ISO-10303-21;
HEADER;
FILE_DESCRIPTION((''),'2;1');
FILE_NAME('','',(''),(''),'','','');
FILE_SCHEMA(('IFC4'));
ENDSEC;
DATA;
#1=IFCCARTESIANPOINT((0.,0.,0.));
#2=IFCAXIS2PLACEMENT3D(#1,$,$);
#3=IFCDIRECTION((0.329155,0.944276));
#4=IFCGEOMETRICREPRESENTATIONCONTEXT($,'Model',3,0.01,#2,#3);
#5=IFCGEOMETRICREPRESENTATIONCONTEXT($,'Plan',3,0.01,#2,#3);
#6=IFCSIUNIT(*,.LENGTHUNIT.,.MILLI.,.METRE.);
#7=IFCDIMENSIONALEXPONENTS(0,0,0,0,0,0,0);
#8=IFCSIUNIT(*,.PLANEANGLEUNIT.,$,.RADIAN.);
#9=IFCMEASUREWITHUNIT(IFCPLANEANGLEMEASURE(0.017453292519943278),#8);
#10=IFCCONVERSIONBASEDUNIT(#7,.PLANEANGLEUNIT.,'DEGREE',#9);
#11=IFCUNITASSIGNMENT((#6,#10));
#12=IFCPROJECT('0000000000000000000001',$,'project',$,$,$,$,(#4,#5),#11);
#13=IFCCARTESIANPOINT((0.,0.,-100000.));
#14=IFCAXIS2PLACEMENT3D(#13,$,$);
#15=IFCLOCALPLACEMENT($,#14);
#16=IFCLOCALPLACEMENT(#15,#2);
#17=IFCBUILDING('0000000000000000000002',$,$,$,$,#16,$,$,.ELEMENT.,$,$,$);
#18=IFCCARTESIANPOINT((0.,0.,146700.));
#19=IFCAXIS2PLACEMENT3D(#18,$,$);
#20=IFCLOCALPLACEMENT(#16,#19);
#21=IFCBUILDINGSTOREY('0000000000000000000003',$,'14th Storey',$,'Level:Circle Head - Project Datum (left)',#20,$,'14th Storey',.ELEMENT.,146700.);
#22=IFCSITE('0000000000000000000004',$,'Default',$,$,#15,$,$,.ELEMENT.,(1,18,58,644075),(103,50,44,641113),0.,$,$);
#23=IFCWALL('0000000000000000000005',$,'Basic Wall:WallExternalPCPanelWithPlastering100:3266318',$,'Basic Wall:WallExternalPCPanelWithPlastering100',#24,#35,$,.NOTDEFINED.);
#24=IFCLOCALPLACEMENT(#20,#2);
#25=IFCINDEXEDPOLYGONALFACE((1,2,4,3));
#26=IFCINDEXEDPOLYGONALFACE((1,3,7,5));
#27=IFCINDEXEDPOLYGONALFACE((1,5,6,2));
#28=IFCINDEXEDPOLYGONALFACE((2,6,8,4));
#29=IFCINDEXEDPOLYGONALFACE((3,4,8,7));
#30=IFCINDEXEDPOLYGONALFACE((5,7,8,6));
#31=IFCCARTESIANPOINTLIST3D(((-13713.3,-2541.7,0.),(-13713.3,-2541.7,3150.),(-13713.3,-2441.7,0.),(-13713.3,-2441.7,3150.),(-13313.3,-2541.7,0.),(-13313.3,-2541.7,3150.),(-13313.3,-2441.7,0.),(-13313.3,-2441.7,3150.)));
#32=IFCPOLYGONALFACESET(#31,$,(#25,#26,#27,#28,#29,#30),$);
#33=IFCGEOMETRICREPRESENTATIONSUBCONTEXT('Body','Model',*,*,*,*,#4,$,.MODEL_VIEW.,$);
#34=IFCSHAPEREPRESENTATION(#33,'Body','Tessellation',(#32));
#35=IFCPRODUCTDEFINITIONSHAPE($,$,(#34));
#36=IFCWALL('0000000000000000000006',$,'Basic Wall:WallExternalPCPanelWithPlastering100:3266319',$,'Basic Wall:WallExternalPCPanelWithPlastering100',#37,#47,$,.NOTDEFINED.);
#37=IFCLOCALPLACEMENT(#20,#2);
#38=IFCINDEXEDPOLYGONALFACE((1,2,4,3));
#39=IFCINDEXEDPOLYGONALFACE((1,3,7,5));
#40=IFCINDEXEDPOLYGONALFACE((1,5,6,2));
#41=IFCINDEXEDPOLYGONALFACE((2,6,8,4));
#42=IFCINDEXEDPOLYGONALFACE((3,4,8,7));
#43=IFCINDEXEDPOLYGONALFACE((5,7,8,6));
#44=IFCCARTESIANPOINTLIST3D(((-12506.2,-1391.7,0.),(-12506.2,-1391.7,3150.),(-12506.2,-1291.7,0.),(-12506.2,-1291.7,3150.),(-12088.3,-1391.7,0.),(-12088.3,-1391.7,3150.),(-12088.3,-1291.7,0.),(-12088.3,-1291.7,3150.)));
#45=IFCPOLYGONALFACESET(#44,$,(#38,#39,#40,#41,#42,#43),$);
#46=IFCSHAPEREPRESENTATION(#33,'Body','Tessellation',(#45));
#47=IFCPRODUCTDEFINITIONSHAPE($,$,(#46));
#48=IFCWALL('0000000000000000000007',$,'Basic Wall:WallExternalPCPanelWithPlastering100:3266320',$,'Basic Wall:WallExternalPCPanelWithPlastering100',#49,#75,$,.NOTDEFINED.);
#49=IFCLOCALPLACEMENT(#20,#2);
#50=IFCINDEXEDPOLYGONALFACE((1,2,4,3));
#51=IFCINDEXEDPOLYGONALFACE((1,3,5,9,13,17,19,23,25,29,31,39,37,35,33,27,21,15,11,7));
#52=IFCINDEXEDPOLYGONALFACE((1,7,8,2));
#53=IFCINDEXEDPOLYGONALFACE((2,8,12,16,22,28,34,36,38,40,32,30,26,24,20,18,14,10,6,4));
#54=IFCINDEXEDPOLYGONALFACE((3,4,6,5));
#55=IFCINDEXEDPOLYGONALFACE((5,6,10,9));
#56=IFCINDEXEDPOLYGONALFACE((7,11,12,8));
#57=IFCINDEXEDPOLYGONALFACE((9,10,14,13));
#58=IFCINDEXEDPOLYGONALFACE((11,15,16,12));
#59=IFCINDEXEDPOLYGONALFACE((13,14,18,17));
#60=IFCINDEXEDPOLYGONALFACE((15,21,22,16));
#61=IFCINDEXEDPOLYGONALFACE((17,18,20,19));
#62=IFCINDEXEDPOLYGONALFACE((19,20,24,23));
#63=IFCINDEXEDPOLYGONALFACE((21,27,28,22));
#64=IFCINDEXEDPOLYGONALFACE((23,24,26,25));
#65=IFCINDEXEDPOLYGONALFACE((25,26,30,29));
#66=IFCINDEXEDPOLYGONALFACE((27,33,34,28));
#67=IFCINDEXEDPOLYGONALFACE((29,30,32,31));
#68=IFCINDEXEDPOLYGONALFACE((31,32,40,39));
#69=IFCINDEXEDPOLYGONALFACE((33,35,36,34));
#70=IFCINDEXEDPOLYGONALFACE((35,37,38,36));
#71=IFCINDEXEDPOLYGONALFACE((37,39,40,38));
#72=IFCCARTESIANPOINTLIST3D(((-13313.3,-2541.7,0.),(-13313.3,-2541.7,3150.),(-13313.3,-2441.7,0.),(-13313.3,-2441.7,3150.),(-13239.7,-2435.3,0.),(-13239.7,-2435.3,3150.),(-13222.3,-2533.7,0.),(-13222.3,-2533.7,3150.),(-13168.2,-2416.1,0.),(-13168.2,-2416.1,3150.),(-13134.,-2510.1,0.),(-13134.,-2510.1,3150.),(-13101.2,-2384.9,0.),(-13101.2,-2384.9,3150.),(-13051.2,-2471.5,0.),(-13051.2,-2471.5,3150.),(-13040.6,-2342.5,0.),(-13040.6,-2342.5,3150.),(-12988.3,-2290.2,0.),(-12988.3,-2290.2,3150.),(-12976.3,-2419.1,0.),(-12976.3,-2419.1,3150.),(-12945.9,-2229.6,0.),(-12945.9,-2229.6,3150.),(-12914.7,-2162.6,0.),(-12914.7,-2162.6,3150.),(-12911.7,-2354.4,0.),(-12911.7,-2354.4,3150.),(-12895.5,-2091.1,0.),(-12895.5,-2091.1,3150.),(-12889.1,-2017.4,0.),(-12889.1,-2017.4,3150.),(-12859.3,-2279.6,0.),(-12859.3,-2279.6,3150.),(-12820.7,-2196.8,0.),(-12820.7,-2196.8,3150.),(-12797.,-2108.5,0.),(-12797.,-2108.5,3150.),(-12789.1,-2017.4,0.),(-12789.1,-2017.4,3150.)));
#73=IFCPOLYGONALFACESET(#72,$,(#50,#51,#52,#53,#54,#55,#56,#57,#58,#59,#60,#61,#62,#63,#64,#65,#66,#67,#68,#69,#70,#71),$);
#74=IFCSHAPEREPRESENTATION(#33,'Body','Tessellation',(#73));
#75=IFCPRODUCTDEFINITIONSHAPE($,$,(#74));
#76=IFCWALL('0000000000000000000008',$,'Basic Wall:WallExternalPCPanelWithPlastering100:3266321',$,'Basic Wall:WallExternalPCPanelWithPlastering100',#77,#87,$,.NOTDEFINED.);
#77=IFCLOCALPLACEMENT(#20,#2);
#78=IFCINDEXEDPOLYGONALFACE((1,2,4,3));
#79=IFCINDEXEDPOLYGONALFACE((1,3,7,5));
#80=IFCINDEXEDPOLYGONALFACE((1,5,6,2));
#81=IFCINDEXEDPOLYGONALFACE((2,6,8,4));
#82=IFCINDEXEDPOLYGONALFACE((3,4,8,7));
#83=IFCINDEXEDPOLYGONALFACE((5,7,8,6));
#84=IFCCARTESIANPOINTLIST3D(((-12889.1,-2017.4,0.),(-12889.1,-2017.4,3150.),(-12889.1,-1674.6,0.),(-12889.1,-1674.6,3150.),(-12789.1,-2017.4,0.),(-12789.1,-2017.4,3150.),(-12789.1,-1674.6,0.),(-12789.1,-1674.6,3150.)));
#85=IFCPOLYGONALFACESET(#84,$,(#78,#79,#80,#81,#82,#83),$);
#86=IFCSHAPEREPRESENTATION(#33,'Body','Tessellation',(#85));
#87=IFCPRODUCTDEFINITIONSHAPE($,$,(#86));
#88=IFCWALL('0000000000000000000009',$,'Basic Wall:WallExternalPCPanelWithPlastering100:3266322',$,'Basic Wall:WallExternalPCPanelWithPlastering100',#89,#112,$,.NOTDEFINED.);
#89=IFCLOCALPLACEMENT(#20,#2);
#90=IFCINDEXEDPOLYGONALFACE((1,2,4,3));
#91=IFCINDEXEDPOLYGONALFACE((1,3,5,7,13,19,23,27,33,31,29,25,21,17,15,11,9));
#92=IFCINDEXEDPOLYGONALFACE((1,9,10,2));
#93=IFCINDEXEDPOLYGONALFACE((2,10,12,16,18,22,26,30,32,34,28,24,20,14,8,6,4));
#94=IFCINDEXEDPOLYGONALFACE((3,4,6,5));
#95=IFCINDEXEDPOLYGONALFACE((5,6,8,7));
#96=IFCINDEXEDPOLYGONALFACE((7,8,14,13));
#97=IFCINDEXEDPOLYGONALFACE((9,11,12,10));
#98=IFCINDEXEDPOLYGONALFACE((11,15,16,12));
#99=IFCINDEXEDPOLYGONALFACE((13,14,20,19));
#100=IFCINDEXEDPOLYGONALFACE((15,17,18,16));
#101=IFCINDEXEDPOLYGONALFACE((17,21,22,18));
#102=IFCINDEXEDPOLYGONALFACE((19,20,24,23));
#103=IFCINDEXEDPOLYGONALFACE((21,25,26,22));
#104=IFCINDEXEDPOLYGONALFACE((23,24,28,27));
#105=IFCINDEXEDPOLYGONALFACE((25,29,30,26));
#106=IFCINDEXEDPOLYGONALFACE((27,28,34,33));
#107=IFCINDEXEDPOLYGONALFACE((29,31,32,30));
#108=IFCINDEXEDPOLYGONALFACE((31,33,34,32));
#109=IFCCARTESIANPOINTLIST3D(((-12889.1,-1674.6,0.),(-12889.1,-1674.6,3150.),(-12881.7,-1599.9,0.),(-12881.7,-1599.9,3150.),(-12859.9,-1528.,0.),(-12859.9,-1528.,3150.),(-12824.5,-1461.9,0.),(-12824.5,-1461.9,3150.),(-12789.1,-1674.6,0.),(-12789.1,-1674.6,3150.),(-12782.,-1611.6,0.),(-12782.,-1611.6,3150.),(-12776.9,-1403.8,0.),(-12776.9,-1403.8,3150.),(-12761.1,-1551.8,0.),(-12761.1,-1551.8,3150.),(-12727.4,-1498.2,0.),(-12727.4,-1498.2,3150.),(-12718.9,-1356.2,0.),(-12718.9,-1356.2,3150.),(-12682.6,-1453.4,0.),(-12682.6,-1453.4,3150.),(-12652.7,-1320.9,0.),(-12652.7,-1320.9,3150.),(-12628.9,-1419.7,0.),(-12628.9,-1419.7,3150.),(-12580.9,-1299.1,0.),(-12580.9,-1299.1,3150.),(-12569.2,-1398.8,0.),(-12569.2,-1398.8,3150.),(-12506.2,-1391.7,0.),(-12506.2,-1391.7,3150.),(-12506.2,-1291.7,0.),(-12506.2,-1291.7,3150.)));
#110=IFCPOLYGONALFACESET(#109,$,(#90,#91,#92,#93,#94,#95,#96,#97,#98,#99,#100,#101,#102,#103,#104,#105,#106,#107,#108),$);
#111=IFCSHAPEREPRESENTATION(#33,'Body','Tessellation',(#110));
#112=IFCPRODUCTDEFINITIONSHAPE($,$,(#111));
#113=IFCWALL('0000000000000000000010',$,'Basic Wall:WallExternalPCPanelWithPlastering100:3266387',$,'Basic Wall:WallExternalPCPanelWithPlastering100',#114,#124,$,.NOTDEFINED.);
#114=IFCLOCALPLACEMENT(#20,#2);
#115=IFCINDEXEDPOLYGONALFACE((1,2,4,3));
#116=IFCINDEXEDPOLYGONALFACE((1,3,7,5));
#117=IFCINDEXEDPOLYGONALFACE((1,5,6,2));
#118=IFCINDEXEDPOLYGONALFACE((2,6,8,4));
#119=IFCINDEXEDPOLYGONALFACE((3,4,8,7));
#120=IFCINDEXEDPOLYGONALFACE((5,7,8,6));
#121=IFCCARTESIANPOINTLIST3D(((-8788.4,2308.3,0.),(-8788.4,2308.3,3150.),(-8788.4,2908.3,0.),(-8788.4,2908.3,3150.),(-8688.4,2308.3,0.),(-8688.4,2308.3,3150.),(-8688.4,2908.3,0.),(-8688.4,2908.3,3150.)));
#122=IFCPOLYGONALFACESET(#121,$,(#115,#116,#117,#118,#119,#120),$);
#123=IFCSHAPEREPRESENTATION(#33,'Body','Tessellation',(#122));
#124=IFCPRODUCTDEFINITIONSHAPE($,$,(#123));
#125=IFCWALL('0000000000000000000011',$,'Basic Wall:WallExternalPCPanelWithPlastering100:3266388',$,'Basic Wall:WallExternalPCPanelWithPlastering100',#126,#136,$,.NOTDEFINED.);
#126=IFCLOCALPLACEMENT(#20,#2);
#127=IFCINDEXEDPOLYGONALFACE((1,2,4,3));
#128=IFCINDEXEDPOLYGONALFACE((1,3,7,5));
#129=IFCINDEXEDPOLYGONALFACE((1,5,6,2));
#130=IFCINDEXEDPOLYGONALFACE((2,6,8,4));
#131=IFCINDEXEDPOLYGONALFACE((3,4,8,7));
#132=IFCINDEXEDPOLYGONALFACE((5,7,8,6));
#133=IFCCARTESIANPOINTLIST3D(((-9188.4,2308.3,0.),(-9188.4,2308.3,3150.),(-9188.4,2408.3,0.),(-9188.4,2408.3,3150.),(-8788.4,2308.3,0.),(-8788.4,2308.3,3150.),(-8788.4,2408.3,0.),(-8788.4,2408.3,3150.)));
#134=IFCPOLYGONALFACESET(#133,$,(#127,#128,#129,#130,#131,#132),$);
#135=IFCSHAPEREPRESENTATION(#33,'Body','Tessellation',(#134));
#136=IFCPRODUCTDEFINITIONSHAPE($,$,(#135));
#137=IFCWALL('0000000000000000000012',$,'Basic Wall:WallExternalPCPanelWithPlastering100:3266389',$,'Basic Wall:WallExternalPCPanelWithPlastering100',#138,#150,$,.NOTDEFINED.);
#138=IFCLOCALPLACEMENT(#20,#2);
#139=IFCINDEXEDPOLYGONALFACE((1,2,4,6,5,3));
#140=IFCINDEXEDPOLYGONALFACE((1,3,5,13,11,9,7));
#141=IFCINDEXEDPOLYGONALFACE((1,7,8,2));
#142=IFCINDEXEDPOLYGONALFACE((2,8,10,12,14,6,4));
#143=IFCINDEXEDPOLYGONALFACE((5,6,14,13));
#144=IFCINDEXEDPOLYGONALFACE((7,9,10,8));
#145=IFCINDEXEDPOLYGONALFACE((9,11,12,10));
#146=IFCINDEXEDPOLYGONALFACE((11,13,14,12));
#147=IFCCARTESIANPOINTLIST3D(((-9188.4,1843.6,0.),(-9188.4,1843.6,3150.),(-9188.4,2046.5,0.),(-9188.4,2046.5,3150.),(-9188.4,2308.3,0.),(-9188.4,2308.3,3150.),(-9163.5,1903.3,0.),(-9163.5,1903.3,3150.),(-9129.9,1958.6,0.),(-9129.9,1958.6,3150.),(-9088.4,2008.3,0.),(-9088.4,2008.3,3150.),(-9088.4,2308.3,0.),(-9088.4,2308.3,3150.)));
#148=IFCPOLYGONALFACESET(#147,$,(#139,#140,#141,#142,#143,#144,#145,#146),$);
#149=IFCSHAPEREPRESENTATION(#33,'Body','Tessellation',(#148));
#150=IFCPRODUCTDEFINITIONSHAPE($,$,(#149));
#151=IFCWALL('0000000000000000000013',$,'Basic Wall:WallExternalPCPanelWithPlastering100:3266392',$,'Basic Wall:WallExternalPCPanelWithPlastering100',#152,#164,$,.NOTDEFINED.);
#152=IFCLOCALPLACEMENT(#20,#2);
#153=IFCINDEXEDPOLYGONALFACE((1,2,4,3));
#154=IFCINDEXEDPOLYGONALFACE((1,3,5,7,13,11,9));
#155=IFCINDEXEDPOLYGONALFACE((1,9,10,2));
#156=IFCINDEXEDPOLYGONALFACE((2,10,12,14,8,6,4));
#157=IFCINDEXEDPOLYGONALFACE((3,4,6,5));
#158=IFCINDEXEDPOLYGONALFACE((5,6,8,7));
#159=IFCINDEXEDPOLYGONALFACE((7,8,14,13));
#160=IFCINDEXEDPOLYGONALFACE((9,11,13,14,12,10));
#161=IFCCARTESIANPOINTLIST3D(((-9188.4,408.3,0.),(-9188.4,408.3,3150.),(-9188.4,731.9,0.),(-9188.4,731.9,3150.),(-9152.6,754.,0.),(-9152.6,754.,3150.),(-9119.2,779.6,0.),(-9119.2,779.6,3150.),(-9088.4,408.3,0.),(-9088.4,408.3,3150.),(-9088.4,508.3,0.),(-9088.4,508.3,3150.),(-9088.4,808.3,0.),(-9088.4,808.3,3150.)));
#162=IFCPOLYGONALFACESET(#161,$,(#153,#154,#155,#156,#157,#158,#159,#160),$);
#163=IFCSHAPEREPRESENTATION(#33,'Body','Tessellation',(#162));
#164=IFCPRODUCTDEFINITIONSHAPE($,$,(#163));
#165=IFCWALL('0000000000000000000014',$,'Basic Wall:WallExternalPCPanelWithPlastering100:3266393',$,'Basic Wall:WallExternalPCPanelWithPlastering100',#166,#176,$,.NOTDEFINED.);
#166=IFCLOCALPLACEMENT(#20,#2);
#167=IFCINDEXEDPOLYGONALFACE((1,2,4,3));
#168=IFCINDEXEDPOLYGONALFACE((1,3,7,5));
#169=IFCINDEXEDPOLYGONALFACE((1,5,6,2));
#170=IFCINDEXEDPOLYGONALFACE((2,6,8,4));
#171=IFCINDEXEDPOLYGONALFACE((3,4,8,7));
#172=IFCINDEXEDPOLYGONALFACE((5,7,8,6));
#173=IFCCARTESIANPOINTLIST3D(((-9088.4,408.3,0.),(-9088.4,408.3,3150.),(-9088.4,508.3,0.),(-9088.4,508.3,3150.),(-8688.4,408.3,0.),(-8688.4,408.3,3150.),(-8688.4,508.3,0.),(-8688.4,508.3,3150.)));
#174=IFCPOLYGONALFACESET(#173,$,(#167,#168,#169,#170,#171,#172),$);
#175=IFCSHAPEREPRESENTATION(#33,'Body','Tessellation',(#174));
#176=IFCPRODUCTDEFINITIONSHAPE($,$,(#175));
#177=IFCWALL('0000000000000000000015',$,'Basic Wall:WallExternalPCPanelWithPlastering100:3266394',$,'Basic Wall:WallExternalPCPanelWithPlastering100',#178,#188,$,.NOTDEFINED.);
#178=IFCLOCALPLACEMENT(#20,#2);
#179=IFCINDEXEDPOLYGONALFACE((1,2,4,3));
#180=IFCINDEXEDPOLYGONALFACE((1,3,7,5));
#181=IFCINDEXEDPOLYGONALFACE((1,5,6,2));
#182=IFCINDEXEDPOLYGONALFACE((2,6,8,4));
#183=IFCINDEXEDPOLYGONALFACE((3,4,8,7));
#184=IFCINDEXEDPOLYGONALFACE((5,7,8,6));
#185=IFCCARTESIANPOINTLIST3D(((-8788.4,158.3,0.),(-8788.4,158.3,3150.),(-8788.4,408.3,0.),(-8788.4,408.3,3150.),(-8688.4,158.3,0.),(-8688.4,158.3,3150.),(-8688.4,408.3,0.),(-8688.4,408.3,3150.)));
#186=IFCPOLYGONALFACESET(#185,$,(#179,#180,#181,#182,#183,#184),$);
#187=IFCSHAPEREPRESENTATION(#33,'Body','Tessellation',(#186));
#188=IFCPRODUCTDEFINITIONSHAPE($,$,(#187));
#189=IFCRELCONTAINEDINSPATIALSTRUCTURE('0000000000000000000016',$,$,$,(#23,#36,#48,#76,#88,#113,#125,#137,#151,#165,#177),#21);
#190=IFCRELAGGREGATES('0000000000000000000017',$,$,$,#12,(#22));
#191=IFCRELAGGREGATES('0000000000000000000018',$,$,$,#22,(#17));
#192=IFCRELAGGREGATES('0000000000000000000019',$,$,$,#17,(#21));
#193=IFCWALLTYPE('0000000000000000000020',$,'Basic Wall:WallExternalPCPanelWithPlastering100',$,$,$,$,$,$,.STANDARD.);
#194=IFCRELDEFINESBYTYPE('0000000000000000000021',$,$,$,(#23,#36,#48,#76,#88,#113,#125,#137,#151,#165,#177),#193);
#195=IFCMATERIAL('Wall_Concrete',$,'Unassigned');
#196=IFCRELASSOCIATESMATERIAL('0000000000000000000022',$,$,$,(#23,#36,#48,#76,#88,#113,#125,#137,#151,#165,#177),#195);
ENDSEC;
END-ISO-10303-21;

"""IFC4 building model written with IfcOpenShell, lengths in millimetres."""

from ifc_helpers import new_model, entity, si_unit, converted_unit, direction, frame, origin, place, context, subcontext, project, spatial, line, arc, indexed_curve, outline, extrude, material, type_object, element, save


model = new_model("IFC4")

# Units and contexts
model_context = context("Model", 3, precision=0.01, world=origin(), true_north=direction((0.329155, 0.944276)))
plan_context = context("Plan", 3, precision=0.01, world=origin(), true_north=direction((0.329155, 0.944276)))
body_context = subcontext(model_context, "Body", "Model", "MODEL_VIEW")
ifc_project = project(units=[si_unit("LENGTHUNIT", "METRE", prefix="MILLI"), converted_unit("PLANEANGLEUNIT", "DEGREE", entity("IfcPlaneAngleMeasure", 0.017453292519943278), si_unit("PLANEANGLEUNIT", "RADIAN"), dimensions=[0, 0, 0, 0, 0, 0, 0])], contexts=[model_context, plan_context])

# Site, building, storey
site_placement = place(None, frame((0.0, 0.0, -100000.0)))
site = spatial("IfcSite", under=ifc_project, at=site_placement, Name="Default", CompositionType="ELEMENT", RefLatitude=(1, 18, 58, 644075), RefLongitude=(103, 50, 44, 641113), RefElevation=0.0)
building_placement = place(site_placement, origin())
building = spatial("IfcBuilding", under=site, at=building_placement, CompositionType="ELEMENT")
storey_placement = place(building_placement, frame((0.0, 0.0, 146700.0)))
storey = spatial("IfcBuildingStorey", under=building, at=storey_placement, Name="14th Storey", ObjectType="Level:Circle Head - Project Datum (left)", LongName="14th Storey", CompositionType="ELEMENT", Elevation=146700.0)

# Walls
ifc_material_1 = material(Name="Wall_Concrete", Category="Unassigned")
wall_type_1 = type_object("IfcWallType", Name="Basic Wall:WallExternalPCPanelWithPlastering100", PredefinedType="STANDARD")
wall_1_placement = place(storey_placement, frame((-13713.3, -2491.7, 0.0)))
element("IfcWall", 1, at=wall_1_placement, inside=storey, type_object=wall_type_1, material=ifc_material_1, Name="Basic Wall:WallExternalPCPanelWithPlastering100:3266318", ObjectType="Basic Wall:WallExternalPCPanelWithPlastering100", PredefinedType="NOTDEFINED", context=body_context, shape_type="SweptSolid", body=[
    extrude(outline(indexed_curve([(400.0, 50.0), (0.0, 50.0), (0.0, -50.0), (400.0, -50.0), (400.0, 50.0)], self_intersect=False)), origin(), (0.0, 0.0, 1.0), 3150.0),
])
wall_2_placement = place(storey_placement, frame((-12088.3, -1341.7, 0.0), z_axis=(0.0, 0.0, 1.0), x_axis=(-1.0, 0.0, 0.0)))
element("IfcWall", 2, at=wall_2_placement, inside=storey, type_object=wall_type_1, material=ifc_material_1, Name="Basic Wall:WallExternalPCPanelWithPlastering100:3266319", ObjectType="Basic Wall:WallExternalPCPanelWithPlastering100", PredefinedType="NOTDEFINED", context=body_context, shape_type="SweptSolid", body=[
    extrude(outline(indexed_curve([(417.9, 50.0), (0.0, 50.0), (0.0, -50.0), (417.9, -50.0), (417.9, 50.0)], self_intersect=False)), origin(), (0.0, 0.0, 1.0), 3150.0),
])
wall_3_placement = place(storey_placement, frame((-13313.3, -2491.7, 0.0)))
element("IfcWall", 3, at=wall_3_placement, inside=storey, type_object=wall_type_1, material=ifc_material_1, Name="Basic Wall:WallExternalPCPanelWithPlastering100:3266320", ObjectType="Basic Wall:WallExternalPCPanelWithPlastering100", PredefinedType="NOTDEFINED", context=body_context, shape_type="SweptSolid", body=[
    extrude(outline(indexed_curve([(424.3, 474.3), (300.0, 174.3), (0.0, 50.0), (0.0, -50.0), (370.7, 103.6), (524.3, 474.3)], segments=[arc(1, 2, 3), line(3, 4), arc(4, 5, 6), line(6, 1)], self_intersect=False)), origin(), (0.0, 0.0, 1.0), 3150.0),
])
wall_4_placement = place(storey_placement, frame((-12839.1, -2017.4, 0.0), z_axis=(0.0, 0.0, 1.0), x_axis=(0.0, 1.0, 0.0)))
element("IfcWall", 4, at=wall_4_placement, inside=storey, type_object=wall_type_1, material=ifc_material_1, Name="Basic Wall:WallExternalPCPanelWithPlastering100:3266321", ObjectType="Basic Wall:WallExternalPCPanelWithPlastering100", PredefinedType="NOTDEFINED", context=body_context, shape_type="SweptSolid", body=[
    extrude(outline(indexed_curve([(342.9, 50.0), (0.0, 50.0), (0.0, -50.0), (342.9, -50.0), (342.9, 50.0)], self_intersect=False)), origin(), (0.0, 0.0, 1.0), 3150.0),
])
wall_5_placement = place(storey_placement, frame((-12506.2, -1341.7, 0.0)))
element("IfcWall", 5, at=wall_5_placement, inside=storey, type_object=wall_type_1, material=ifc_material_1, Name="Basic Wall:WallExternalPCPanelWithPlastering100:3266322", ObjectType="Basic Wall:WallExternalPCPanelWithPlastering100", PredefinedType="NOTDEFINED", context=body_context, shape_type="SweptSolid", body=[
    extrude(outline(indexed_curve([(-282.8, -332.8), (-200.0, -132.8), (0.0, -50.0), (0.0, 50.0), (-270.7, -62.1), (-382.8, -332.8)], segments=[arc(1, 2, 3), line(3, 4), arc(4, 5, 6), line(6, 1)], self_intersect=False)), origin(), (0.0, 0.0, 1.0), 3150.0),
])
wall_6_placement = place(storey_placement, frame((-8738.4, 2908.3, 0.0), z_axis=(0.0, 0.0, 1.0), x_axis=(0.0, -1.0, 0.0)))
element("IfcWall", 6, at=wall_6_placement, inside=storey, type_object=wall_type_1, material=ifc_material_1, Name="Basic Wall:WallExternalPCPanelWithPlastering100:3266387", ObjectType="Basic Wall:WallExternalPCPanelWithPlastering100", PredefinedType="NOTDEFINED", context=body_context, shape_type="SweptSolid", body=[
    extrude(outline(indexed_curve([(600.0, 50.0), (0.0, 50.0), (0.0, -50.0), (600.0, -50.0), (600.0, 50.0)], self_intersect=False)), origin(), (0.0, 0.0, 1.0), 3150.0),
])
wall_7_placement = place(storey_placement, frame((-8788.4, 2358.3, 0.0), z_axis=(0.0, 0.0, 1.0), x_axis=(-1.0, 0.0, 0.0)))
element("IfcWall", 7, at=wall_7_placement, inside=storey, type_object=wall_type_1, material=ifc_material_1, Name="Basic Wall:WallExternalPCPanelWithPlastering100:3266388", ObjectType="Basic Wall:WallExternalPCPanelWithPlastering100", PredefinedType="NOTDEFINED", context=body_context, shape_type="SweptSolid", body=[
    extrude(outline(indexed_curve([(400.0, 50.0), (0.0, 50.0), (0.0, -50.0), (400.0, -50.0), (400.0, 50.0)], self_intersect=False)), origin(), (0.0, 0.0, 1.0), 3150.0),
])
wall_8_placement = place(storey_placement, frame((-9138.4, 2308.3, 0.0), z_axis=(0.0, 0.0, 1.0), x_axis=(0.0, -1.0, 0.0)))
element("IfcWall", 8, at=wall_8_placement, inside=storey, type_object=wall_type_1, material=ifc_material_1, Name="Basic Wall:WallExternalPCPanelWithPlastering100:3266389", ObjectType="Basic Wall:WallExternalPCPanelWithPlastering100", PredefinedType="NOTDEFINED", context=body_context, shape_type="SweptSolid", body=[
    extrude(outline(indexed_curve([(464.7, -50.0), (376.7, -9.3), (300.0, 50.0), (0.0, 50.0), (0.0, -50.0), (261.8, -50.0)], segments=[arc(1, 2, 3), line(3, 4, 5, 6, 1)], self_intersect=False)), origin(), (0.0, 0.0, 1.0), 3150.0),
])
wall_9_placement = place(storey_placement, frame((-9138.4, 808.3, 0.0), z_axis=(0.0, 0.0, 1.0), x_axis=(0.0, -1.0, 0.0)))
element("IfcWall", 9, at=wall_9_placement, inside=storey, type_object=wall_type_1, material=ifc_material_1, Name="Basic Wall:WallExternalPCPanelWithPlastering100:3266392", ObjectType="Basic Wall:WallExternalPCPanelWithPlastering100", PredefinedType="NOTDEFINED", context=body_context, shape_type="SweptSolid", body=[
    extrude(outline(indexed_curve([(400.0, -50.0), (400.0, 50.0), (300.0, 50.0), (0.0, 50.0), (41.9, 2.8), (76.4, -50.0)], segments=[line(1, 2, 3, 4), arc(4, 5, 6), line(6, 1)], self_intersect=False)), origin(), (0.0, 0.0, 1.0), 3150.0),
])
wall_10_placement = place(storey_placement, frame((-9088.4, 458.3, 0.0)))
element("IfcWall", 10, at=wall_10_placement, inside=storey, type_object=wall_type_1, material=ifc_material_1, Name="Basic Wall:WallExternalPCPanelWithPlastering100:3266393", ObjectType="Basic Wall:WallExternalPCPanelWithPlastering100", PredefinedType="NOTDEFINED", context=body_context, shape_type="SweptSolid", body=[
    extrude(outline(indexed_curve([(400.0, 50.0), (0.0, 50.0), (0.0, -50.0), (400.0, -50.0), (400.0, 50.0)], self_intersect=False)), origin(), (0.0, 0.0, 1.0), 3150.0),
])
wall_11_placement = place(storey_placement, frame((-8738.4, 408.3, 0.0), z_axis=(0.0, 0.0, 1.0), x_axis=(0.0, -1.0, 0.0)))
element("IfcWall", 11, at=wall_11_placement, inside=storey, type_object=wall_type_1, material=ifc_material_1, Name="Basic Wall:WallExternalPCPanelWithPlastering100:3266394", ObjectType="Basic Wall:WallExternalPCPanelWithPlastering100", PredefinedType="NOTDEFINED", context=body_context, shape_type="SweptSolid", body=[
    extrude(outline(indexed_curve([(250.0, 50.0), (0.0, 50.0), (0.0, -50.0), (250.0, -50.0), (250.0, 50.0)], self_intersect=False)), origin(), (0.0, 0.0, 1.0), 3150.0),
])

save(model, "model.ifc")
